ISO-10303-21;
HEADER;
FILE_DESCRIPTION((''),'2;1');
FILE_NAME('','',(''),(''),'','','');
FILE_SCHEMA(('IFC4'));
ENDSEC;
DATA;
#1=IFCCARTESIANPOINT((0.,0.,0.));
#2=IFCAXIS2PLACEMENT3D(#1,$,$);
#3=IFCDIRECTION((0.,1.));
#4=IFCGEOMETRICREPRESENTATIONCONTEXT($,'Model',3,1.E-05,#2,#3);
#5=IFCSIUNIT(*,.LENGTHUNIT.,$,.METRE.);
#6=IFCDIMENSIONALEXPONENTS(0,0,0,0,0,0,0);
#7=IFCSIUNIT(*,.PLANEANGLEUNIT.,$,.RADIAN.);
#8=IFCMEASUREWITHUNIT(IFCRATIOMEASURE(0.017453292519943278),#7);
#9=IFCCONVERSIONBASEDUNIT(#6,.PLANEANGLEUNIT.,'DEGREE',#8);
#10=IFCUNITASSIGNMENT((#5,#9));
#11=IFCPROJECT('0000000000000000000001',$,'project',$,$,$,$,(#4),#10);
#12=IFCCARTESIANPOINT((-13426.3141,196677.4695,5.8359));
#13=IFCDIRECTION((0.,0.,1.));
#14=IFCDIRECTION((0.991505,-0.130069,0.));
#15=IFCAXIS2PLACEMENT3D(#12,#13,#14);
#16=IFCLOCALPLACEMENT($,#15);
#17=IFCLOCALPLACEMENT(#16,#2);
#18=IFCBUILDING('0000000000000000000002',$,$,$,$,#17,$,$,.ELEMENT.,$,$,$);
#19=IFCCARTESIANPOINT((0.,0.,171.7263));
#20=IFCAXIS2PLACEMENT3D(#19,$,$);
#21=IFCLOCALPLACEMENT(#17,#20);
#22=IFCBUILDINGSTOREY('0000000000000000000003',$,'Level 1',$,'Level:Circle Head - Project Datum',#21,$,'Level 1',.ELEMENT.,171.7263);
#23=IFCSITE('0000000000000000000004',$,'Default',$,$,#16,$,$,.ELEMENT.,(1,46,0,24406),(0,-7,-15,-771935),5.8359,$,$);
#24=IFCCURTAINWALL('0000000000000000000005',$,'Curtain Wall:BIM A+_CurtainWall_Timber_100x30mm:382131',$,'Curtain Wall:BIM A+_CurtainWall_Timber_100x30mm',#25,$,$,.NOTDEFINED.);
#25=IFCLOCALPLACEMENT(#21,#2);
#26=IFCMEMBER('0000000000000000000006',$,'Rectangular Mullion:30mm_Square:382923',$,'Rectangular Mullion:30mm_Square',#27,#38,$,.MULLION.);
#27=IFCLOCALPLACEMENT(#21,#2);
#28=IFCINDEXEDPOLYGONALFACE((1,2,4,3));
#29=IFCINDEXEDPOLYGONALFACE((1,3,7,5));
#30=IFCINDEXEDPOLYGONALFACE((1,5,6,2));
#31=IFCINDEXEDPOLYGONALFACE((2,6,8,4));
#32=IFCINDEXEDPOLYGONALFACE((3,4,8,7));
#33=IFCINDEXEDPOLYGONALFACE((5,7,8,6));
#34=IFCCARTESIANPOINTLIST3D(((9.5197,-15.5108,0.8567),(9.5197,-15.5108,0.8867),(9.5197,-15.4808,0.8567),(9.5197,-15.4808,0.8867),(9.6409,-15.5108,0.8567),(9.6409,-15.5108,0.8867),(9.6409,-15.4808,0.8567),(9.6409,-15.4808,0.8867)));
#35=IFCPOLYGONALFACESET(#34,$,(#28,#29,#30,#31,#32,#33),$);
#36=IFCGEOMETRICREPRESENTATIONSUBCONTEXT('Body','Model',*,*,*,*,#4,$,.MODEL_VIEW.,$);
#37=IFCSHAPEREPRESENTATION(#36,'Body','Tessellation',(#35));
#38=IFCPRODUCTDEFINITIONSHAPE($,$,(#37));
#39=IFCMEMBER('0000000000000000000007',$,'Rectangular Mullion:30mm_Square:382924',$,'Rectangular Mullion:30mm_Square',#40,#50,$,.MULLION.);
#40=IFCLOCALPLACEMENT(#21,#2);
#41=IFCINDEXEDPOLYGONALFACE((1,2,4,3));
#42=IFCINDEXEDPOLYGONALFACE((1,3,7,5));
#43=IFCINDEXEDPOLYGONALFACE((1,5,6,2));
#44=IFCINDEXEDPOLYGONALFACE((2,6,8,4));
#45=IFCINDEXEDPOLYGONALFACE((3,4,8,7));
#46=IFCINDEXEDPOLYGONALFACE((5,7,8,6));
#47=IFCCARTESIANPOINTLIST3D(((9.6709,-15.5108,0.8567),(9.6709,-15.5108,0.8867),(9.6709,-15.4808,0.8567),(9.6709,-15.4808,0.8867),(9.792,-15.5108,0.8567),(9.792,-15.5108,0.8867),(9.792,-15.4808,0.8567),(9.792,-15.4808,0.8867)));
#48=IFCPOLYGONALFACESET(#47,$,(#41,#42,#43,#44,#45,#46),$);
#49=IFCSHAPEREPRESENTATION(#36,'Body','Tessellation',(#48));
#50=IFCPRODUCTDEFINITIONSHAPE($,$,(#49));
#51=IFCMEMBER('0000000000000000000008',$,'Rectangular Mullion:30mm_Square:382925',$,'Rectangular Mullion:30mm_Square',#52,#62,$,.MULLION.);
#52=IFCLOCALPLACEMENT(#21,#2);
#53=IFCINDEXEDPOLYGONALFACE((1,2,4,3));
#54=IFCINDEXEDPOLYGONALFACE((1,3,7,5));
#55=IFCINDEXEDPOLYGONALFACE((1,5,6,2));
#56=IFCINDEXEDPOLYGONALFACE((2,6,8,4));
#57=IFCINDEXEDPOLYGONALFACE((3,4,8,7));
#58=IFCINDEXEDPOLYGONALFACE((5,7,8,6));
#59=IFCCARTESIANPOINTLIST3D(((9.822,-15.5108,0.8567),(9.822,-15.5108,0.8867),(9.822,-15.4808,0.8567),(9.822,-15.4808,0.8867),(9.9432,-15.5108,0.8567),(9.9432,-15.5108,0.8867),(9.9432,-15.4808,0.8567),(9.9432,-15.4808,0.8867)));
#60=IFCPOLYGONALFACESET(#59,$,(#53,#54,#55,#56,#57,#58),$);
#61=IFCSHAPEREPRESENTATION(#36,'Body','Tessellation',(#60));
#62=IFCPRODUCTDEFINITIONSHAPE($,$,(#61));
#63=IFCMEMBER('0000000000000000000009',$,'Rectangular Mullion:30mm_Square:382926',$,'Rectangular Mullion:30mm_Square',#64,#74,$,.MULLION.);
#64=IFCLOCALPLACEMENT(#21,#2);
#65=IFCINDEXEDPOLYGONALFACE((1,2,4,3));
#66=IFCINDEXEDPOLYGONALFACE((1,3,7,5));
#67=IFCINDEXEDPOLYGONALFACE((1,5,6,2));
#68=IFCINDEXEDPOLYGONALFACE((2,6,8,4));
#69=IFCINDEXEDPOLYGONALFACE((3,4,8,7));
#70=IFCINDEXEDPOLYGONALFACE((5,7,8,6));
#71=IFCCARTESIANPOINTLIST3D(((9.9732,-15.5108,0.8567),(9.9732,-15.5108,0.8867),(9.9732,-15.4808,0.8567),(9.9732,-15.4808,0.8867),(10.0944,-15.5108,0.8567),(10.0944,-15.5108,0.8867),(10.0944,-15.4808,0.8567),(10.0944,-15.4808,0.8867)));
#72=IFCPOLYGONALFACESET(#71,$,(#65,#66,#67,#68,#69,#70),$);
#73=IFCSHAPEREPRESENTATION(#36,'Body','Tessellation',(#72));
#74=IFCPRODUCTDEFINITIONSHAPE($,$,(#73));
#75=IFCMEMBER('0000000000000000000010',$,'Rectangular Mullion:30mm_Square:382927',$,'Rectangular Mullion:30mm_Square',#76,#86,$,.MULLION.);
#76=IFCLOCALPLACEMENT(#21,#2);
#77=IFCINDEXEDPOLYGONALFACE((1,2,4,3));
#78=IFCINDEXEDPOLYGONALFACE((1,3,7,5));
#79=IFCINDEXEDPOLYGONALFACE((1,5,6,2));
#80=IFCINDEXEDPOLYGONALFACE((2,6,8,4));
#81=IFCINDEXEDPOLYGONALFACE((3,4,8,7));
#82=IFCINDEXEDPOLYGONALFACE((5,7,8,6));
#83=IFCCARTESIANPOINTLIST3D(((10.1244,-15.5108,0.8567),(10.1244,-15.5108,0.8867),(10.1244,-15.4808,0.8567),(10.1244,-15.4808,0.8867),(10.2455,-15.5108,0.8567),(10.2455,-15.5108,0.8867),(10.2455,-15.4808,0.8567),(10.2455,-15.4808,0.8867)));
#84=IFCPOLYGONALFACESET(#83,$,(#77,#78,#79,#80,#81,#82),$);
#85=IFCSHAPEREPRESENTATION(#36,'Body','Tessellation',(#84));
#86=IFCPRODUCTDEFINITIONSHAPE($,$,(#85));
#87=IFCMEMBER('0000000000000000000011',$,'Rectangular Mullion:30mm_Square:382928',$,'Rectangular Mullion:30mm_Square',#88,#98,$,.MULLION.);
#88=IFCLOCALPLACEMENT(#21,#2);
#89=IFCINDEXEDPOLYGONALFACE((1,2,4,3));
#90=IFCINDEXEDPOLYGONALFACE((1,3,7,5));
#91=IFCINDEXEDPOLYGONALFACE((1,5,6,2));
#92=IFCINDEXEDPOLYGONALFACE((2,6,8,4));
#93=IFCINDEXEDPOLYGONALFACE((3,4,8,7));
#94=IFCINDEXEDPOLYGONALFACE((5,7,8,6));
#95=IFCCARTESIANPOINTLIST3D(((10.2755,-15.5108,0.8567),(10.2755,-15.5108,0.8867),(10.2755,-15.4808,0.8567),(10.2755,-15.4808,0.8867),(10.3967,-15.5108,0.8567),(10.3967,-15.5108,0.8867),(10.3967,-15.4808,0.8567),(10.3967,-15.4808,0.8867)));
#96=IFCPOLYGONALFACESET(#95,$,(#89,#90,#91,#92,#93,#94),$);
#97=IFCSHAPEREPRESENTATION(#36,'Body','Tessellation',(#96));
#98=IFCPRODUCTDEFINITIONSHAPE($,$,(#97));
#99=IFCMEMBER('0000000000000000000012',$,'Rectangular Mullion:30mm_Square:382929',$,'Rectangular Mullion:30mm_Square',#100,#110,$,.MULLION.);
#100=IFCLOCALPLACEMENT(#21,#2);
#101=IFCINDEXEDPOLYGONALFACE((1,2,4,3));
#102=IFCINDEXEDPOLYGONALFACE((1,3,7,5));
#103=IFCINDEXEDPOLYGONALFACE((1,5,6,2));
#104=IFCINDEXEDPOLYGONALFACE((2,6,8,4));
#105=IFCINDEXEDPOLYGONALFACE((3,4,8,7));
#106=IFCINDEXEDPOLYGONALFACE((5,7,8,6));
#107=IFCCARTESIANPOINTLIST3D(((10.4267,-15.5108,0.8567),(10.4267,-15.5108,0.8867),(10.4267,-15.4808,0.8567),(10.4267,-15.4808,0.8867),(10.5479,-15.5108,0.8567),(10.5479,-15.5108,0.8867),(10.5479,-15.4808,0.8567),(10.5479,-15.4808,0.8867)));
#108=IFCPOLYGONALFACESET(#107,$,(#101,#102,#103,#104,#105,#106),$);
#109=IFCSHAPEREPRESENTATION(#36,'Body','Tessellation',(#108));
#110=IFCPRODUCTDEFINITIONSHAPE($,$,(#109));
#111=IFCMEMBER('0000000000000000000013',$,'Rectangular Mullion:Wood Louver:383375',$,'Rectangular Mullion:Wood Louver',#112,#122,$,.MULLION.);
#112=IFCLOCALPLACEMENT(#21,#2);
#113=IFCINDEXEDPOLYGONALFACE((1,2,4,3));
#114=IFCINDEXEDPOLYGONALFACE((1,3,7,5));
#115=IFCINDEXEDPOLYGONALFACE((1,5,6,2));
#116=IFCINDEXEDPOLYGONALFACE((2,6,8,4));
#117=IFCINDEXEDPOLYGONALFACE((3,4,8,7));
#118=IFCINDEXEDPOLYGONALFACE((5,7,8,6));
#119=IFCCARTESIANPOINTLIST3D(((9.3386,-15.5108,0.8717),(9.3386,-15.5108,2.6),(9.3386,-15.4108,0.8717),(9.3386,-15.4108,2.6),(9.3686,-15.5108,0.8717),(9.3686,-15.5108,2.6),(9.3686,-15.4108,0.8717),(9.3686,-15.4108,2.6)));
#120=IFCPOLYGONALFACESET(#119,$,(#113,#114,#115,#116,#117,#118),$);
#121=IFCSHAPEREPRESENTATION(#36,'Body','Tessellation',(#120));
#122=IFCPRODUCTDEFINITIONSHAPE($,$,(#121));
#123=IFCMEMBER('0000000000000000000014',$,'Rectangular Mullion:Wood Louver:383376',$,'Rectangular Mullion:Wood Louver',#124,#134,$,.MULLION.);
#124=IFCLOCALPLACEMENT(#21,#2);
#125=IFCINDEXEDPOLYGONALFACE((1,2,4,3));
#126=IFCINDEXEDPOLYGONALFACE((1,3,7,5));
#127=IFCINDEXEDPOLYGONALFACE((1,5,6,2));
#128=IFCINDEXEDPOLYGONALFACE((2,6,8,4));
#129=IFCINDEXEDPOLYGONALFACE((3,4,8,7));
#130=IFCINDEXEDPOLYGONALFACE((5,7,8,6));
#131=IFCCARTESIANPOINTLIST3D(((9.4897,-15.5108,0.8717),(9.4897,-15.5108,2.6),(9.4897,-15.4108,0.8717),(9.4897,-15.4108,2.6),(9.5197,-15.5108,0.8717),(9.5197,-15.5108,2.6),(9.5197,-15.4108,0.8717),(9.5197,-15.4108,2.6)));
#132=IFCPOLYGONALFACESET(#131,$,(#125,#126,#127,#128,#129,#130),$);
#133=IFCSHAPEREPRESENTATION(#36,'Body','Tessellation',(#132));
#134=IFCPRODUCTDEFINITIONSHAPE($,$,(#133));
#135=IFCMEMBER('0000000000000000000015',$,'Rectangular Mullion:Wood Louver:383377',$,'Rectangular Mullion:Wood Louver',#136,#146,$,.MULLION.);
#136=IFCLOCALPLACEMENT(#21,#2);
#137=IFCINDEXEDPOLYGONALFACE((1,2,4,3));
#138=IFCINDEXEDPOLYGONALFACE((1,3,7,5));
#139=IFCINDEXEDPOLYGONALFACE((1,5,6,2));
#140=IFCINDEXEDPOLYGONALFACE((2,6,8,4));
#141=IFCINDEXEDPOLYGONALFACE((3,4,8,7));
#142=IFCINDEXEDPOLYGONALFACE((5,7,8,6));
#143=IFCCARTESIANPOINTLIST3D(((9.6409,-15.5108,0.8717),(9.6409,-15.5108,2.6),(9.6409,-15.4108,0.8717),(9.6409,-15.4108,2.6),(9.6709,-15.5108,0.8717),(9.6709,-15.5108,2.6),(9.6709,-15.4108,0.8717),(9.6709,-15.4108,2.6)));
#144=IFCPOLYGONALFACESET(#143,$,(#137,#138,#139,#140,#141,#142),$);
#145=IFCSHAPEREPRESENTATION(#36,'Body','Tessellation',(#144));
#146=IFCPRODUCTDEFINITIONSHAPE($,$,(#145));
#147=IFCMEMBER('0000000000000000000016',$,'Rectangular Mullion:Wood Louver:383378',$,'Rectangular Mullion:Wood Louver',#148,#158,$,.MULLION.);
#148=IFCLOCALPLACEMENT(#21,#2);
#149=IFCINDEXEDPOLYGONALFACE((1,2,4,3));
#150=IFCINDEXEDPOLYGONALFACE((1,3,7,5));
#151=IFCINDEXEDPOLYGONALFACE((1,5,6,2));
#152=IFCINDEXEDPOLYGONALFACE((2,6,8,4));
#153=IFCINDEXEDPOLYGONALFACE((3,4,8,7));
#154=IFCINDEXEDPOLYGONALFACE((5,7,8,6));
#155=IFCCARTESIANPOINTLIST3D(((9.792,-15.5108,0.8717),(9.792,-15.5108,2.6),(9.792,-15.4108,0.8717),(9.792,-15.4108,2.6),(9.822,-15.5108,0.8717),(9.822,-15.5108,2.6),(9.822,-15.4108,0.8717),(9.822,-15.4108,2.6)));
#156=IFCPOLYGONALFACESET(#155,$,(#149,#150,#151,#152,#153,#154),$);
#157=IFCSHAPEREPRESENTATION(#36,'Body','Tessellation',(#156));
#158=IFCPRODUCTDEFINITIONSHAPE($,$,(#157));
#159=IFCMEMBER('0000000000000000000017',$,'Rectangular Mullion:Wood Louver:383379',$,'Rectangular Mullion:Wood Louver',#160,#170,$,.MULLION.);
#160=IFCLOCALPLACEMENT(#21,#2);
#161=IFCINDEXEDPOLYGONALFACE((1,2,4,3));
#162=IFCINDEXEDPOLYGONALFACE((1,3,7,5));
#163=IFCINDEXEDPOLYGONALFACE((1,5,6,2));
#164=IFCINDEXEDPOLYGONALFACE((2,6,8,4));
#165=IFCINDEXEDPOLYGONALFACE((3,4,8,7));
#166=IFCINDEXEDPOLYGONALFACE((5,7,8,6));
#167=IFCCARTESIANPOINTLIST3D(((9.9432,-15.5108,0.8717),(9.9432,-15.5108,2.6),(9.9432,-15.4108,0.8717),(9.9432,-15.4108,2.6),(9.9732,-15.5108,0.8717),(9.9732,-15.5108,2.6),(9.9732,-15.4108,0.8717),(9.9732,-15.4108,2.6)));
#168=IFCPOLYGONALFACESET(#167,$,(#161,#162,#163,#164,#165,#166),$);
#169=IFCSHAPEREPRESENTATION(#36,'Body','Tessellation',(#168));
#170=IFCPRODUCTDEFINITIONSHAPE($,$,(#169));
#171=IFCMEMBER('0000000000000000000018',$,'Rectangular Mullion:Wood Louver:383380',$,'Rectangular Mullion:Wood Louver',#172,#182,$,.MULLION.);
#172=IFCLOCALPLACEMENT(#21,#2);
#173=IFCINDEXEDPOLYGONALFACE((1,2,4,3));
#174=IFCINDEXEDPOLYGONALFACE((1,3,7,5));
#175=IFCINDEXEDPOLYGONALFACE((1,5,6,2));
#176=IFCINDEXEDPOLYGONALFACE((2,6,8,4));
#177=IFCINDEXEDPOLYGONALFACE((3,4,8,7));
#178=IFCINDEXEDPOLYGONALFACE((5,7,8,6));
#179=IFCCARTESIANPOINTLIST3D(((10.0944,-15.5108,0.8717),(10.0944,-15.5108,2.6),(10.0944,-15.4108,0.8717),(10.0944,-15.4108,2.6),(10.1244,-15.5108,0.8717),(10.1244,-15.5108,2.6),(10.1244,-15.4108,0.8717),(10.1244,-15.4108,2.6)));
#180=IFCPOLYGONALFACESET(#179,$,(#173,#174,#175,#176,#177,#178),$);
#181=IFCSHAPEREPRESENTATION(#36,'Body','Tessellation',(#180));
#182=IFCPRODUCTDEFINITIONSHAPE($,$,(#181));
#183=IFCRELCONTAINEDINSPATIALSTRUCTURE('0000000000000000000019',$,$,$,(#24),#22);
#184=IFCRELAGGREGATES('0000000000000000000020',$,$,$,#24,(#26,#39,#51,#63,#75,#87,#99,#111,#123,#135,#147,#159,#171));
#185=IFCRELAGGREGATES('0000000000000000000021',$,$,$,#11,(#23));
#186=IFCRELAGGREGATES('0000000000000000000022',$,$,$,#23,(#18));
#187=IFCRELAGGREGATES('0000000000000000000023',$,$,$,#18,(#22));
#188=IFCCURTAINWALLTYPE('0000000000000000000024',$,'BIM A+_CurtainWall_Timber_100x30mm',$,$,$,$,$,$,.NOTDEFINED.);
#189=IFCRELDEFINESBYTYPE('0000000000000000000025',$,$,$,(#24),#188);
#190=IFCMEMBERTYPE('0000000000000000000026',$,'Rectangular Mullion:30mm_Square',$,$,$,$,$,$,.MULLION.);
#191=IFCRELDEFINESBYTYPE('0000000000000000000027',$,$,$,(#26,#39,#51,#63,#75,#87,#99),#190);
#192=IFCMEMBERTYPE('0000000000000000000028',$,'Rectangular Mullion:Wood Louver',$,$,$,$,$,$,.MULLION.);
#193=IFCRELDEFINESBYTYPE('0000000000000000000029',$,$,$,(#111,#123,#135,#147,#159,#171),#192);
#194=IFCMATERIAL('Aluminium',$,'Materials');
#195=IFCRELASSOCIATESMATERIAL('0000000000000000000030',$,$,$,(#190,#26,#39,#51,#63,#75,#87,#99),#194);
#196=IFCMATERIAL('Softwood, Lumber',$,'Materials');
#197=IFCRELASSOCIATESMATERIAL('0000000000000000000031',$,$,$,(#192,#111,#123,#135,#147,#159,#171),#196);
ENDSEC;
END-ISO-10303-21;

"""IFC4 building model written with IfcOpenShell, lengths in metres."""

from ifc_helpers import new_model, entity, si_unit, converted_unit, direction, frame, origin, place, context, subcontext, project, spatial, indexed_curve, outline, extrude, source, transform, mapped, material, type_object, type_shapes, element, aggregate, save


model = new_model("IFC4")

# Units and contexts
model_context = context("Model", 3, precision=1e-05, world=origin(), true_north=direction((0.0, 1.0)))
body_context = subcontext(model_context, "Body", "Model", "MODEL_VIEW")
ifc_project = project(units=[si_unit("LENGTHUNIT", "METRE"), converted_unit("PLANEANGLEUNIT", "DEGREE", entity("IfcRatioMeasure", 0.017453292519943278), si_unit("PLANEANGLEUNIT", "RADIAN"), dimensions=[0, 0, 0, 0, 0, 0, 0])], contexts=[model_context])

# Site, building, storey
site_placement = place(None, frame((-13426.3141, 196677.4695, 5.8359), z_axis=(0.0, 0.0, 1.0), x_axis=(0.991505, -0.130069, 0.0)))
site = spatial("IfcSite", under=ifc_project, at=site_placement, Name="Default", CompositionType="ELEMENT", RefLatitude=(1, 46, 0, 24406), RefLongitude=(0, -7, -15, -771935), RefElevation=5.8359)
building_placement = place(site_placement, origin())
building = spatial("IfcBuilding", under=site, at=building_placement, CompositionType="ELEMENT")
storey_placement = place(building_placement, frame((0.0, 0.0, 171.7263)))
storey = spatial("IfcBuildingStorey", under=building, at=storey_placement, Name="Level 1", ObjectType="Level:Circle Head - Project Datum", LongName="Level 1", CompositionType="ELEMENT", Elevation=171.7263)

# Shared definitions
ifc_material_1 = material(Name="Aluminium", Category="Materials")

# Curtain wall, members
curtain_wall_type_1 = type_object("IfcCurtainWallType", Name="BIM A+_CurtainWall_Timber_100x30mm", PredefinedType="NOTDEFINED")
curtain_wall_1_placement = place(storey_placement, frame((0.0, 0.0, -171.7263)))
curtain_wall_1 = element("IfcCurtainWall", 1, at=curtain_wall_1_placement, inside=storey, type_object=curtain_wall_type_1, Name="Curtain Wall:BIM A+_CurtainWall_Timber_100x30mm:382131", ObjectType="Curtain Wall:BIM A+_CurtainWall_Timber_100x30mm", PredefinedType="NOTDEFINED")
member_type_1 = type_object("IfcMemberType", Name="Rectangular Mullion:30mm_Square", PredefinedType="MULLION", material=ifc_material_1)
shared_shape_1 = source(origin(), body_context, "Body", "SweptSolid", [
    extrude(outline(indexed_curve([(-0.015, -0.015), (0.015, -0.015), (0.015, 0.015), (-0.015, 0.015), (-0.015, -0.015)], self_intersect=False)), frame((0.0, 0.0, -0.1212), z_axis=(0.0, 0.0, 1.0), x_axis=(0.0, -1.0, 0.0)), (0.0, 0.0, 1.0), 0.1212),
])
type_shapes(member_type_1, [shared_shape_1])
member_1_placement = place(curtain_wall_1_placement, frame((9.6409, -15.4958, 172.598), z_axis=(1.0, 0.0, 0.0), x_axis=(0.0, 0.0, 1.0)))
member_1 = element("IfcMember", 2, at=member_1_placement, type_object=member_type_1, material=ifc_material_1, Name="Rectangular Mullion:30mm_Square:382923", ObjectType="Rectangular Mullion:30mm_Square", PredefinedType="MULLION", context=body_context, shape_type="MappedRepresentation", body=[
    mapped(shared_shape_1, transform((0.0, 0.0, 0.0), scale=1.0)),
])
member_2_placement = place(curtain_wall_1_placement, frame((9.792, -15.4958, 172.598), z_axis=(1.0, 0.0, 0.0), x_axis=(0.0, 0.0, 1.0)))
member_2 = element("IfcMember", 3, at=member_2_placement, type_object=member_type_1, material=ifc_material_1, Name="Rectangular Mullion:30mm_Square:382924", ObjectType="Rectangular Mullion:30mm_Square", PredefinedType="MULLION", context=body_context, shape_type="MappedRepresentation", body=[
    mapped(shared_shape_1, transform((0.0, 0.0, 0.0), scale=1.0)),
])
member_3_placement = place(curtain_wall_1_placement, frame((9.9432, -15.4958, 172.598), z_axis=(1.0, 0.0, 0.0), x_axis=(0.0, 0.0, 1.0)))
member_3 = element("IfcMember", 4, at=member_3_placement, type_object=member_type_1, material=ifc_material_1, Name="Rectangular Mullion:30mm_Square:382925", ObjectType="Rectangular Mullion:30mm_Square", PredefinedType="MULLION", context=body_context, shape_type="MappedRepresentation", body=[
    mapped(shared_shape_1, transform((0.0, 0.0, 0.0), scale=1.0)),
])
member_4_placement = place(curtain_wall_1_placement, frame((10.0944, -15.4958, 172.598), z_axis=(1.0, 0.0, 0.0), x_axis=(0.0, 0.0, 1.0)))
member_4 = element("IfcMember", 5, at=member_4_placement, type_object=member_type_1, material=ifc_material_1, Name="Rectangular Mullion:30mm_Square:382926", ObjectType="Rectangular Mullion:30mm_Square", PredefinedType="MULLION", context=body_context, shape_type="MappedRepresentation", body=[
    mapped(shared_shape_1, transform((0.0, 0.0, 0.0), scale=1.0)),
])
member_5_placement = place(curtain_wall_1_placement, frame((10.2455, -15.4958, 172.598), z_axis=(1.0, 0.0, 0.0), x_axis=(0.0, 0.0, 1.0)))
member_5 = element("IfcMember", 6, at=member_5_placement, type_object=member_type_1, material=ifc_material_1, Name="Rectangular Mullion:30mm_Square:382927", ObjectType="Rectangular Mullion:30mm_Square", PredefinedType="MULLION", context=body_context, shape_type="MappedRepresentation", body=[
    mapped(shared_shape_1, transform((0.0, 0.0, 0.0), scale=1.0)),
])
member_6_placement = place(curtain_wall_1_placement, frame((10.3967, -15.4958, 172.598), z_axis=(1.0, 0.0, 0.0), x_axis=(0.0, 0.0, 1.0)))
member_6 = element("IfcMember", 7, at=member_6_placement, type_object=member_type_1, material=ifc_material_1, Name="Rectangular Mullion:30mm_Square:382928", ObjectType="Rectangular Mullion:30mm_Square", PredefinedType="MULLION", context=body_context, shape_type="MappedRepresentation", body=[
    mapped(shared_shape_1, transform((0.0, 0.0, 0.0), scale=1.0)),
])
member_7_placement = place(curtain_wall_1_placement, frame((10.5479, -15.4958, 172.598), z_axis=(1.0, 0.0, 0.0), x_axis=(0.0, 0.0, 1.0)))
member_7 = element("IfcMember", 8, at=member_7_placement, type_object=member_type_1, material=ifc_material_1, Name="Rectangular Mullion:30mm_Square:382929", ObjectType="Rectangular Mullion:30mm_Square", PredefinedType="MULLION", context=body_context, shape_type="MappedRepresentation", body=[
    mapped(shared_shape_1, transform((0.0, 0.0, 0.0), scale=1.0)),
])
ifc_material_2 = material(Name="Softwood, Lumber", Category="Materials")
member_type_2 = type_object("IfcMemberType", Name="Rectangular Mullion:Wood Louver", PredefinedType="MULLION", material=ifc_material_2)
shared_shape_2 = source(origin(), body_context, "Body", "SweptSolid", [
    extrude(outline(indexed_curve([(-0.05, -0.015), (0.05, -0.015), (0.05, 0.015), (-0.05, 0.015), (-0.05, -0.015)], self_intersect=False)), frame((0.0, -0.035, -1.7283), z_axis=(0.0, 0.0, 1.0), x_axis=(0.0, -1.0, 0.0)), (0.0, 0.0, 1.0), 1.7283),
])
type_shapes(member_type_2, [shared_shape_2])
member_8_placement = place(curtain_wall_1_placement, frame((9.3536, -15.4958, 172.598), z_axis=(0.0, 0.0, -1.0), x_axis=(1.0, 0.0, 0.0)))
member_8 = element("IfcMember", 9, at=member_8_placement, type_object=member_type_2, material=ifc_material_2, Name="Rectangular Mullion:Wood Louver:383375", ObjectType="Rectangular Mullion:Wood Louver", PredefinedType="MULLION", context=body_context, shape_type="MappedRepresentation", body=[
    mapped(shared_shape_2, transform((0.0, 0.0, 0.0), scale=1.0)),
])
member_9_placement = place(curtain_wall_1_placement, frame((9.5047, -15.4958, 172.598), z_axis=(0.0, 0.0, -1.0), x_axis=(1.0, 0.0, 0.0)))
member_9 = element("IfcMember", 10, at=member_9_placement, type_object=member_type_2, material=ifc_material_2, Name="Rectangular Mullion:Wood Louver:383376", ObjectType="Rectangular Mullion:Wood Louver", PredefinedType="MULLION", context=body_context, shape_type="MappedRepresentation", body=[
    mapped(shared_shape_2, transform((0.0, 0.0, 0.0), scale=1.0)),
])
member_10_placement = place(curtain_wall_1_placement, frame((9.6559, -15.4958, 172.598), z_axis=(0.0, 0.0, -1.0), x_axis=(1.0, 0.0, 0.0)))
member_10 = element("IfcMember", 11, at=member_10_placement, type_object=member_type_2, material=ifc_material_2, Name="Rectangular Mullion:Wood Louver:383377", ObjectType="Rectangular Mullion:Wood Louver", PredefinedType="MULLION", context=body_context, shape_type="MappedRepresentation", body=[
    mapped(shared_shape_2, transform((0.0, 0.0, 0.0), scale=1.0)),
])
member_11_placement = place(curtain_wall_1_placement, frame((9.807, -15.4958, 172.598), z_axis=(0.0, 0.0, -1.0), x_axis=(1.0, 0.0, 0.0)))
member_11 = element("IfcMember", 12, at=member_11_placement, type_object=member_type_2, material=ifc_material_2, Name="Rectangular Mullion:Wood Louver:383378", ObjectType="Rectangular Mullion:Wood Louver", PredefinedType="MULLION", context=body_context, shape_type="MappedRepresentation", body=[
    mapped(shared_shape_2, transform((0.0, 0.0, 0.0), scale=1.0)),
])
member_12_placement = place(curtain_wall_1_placement, frame((9.9582, -15.4958, 172.598), z_axis=(0.0, 0.0, -1.0), x_axis=(1.0, 0.0, 0.0)))
member_12 = element("IfcMember", 13, at=member_12_placement, type_object=member_type_2, material=ifc_material_2, Name="Rectangular Mullion:Wood Louver:383379", ObjectType="Rectangular Mullion:Wood Louver", PredefinedType="MULLION", context=body_context, shape_type="MappedRepresentation", body=[
    mapped(shared_shape_2, transform((0.0, 0.0, 0.0), scale=1.0)),
])
member_13_placement = place(curtain_wall_1_placement, frame((10.1094, -15.4958, 172.598), z_axis=(0.0, 0.0, -1.0), x_axis=(1.0, 0.0, 0.0)))
member_13 = element("IfcMember", 14, at=member_13_placement, type_object=member_type_2, material=ifc_material_2, Name="Rectangular Mullion:Wood Louver:383380", ObjectType="Rectangular Mullion:Wood Louver", PredefinedType="MULLION", context=body_context, shape_type="MappedRepresentation", body=[
    mapped(shared_shape_2, transform((0.0, 0.0, 0.0), scale=1.0)),
])

aggregate(curtain_wall_1, [member_1, member_2, member_3, member_4, member_5, member_6, member_7, member_8, member_9, member_10, member_11, member_12, member_13])

save(model, "model.ifc")
